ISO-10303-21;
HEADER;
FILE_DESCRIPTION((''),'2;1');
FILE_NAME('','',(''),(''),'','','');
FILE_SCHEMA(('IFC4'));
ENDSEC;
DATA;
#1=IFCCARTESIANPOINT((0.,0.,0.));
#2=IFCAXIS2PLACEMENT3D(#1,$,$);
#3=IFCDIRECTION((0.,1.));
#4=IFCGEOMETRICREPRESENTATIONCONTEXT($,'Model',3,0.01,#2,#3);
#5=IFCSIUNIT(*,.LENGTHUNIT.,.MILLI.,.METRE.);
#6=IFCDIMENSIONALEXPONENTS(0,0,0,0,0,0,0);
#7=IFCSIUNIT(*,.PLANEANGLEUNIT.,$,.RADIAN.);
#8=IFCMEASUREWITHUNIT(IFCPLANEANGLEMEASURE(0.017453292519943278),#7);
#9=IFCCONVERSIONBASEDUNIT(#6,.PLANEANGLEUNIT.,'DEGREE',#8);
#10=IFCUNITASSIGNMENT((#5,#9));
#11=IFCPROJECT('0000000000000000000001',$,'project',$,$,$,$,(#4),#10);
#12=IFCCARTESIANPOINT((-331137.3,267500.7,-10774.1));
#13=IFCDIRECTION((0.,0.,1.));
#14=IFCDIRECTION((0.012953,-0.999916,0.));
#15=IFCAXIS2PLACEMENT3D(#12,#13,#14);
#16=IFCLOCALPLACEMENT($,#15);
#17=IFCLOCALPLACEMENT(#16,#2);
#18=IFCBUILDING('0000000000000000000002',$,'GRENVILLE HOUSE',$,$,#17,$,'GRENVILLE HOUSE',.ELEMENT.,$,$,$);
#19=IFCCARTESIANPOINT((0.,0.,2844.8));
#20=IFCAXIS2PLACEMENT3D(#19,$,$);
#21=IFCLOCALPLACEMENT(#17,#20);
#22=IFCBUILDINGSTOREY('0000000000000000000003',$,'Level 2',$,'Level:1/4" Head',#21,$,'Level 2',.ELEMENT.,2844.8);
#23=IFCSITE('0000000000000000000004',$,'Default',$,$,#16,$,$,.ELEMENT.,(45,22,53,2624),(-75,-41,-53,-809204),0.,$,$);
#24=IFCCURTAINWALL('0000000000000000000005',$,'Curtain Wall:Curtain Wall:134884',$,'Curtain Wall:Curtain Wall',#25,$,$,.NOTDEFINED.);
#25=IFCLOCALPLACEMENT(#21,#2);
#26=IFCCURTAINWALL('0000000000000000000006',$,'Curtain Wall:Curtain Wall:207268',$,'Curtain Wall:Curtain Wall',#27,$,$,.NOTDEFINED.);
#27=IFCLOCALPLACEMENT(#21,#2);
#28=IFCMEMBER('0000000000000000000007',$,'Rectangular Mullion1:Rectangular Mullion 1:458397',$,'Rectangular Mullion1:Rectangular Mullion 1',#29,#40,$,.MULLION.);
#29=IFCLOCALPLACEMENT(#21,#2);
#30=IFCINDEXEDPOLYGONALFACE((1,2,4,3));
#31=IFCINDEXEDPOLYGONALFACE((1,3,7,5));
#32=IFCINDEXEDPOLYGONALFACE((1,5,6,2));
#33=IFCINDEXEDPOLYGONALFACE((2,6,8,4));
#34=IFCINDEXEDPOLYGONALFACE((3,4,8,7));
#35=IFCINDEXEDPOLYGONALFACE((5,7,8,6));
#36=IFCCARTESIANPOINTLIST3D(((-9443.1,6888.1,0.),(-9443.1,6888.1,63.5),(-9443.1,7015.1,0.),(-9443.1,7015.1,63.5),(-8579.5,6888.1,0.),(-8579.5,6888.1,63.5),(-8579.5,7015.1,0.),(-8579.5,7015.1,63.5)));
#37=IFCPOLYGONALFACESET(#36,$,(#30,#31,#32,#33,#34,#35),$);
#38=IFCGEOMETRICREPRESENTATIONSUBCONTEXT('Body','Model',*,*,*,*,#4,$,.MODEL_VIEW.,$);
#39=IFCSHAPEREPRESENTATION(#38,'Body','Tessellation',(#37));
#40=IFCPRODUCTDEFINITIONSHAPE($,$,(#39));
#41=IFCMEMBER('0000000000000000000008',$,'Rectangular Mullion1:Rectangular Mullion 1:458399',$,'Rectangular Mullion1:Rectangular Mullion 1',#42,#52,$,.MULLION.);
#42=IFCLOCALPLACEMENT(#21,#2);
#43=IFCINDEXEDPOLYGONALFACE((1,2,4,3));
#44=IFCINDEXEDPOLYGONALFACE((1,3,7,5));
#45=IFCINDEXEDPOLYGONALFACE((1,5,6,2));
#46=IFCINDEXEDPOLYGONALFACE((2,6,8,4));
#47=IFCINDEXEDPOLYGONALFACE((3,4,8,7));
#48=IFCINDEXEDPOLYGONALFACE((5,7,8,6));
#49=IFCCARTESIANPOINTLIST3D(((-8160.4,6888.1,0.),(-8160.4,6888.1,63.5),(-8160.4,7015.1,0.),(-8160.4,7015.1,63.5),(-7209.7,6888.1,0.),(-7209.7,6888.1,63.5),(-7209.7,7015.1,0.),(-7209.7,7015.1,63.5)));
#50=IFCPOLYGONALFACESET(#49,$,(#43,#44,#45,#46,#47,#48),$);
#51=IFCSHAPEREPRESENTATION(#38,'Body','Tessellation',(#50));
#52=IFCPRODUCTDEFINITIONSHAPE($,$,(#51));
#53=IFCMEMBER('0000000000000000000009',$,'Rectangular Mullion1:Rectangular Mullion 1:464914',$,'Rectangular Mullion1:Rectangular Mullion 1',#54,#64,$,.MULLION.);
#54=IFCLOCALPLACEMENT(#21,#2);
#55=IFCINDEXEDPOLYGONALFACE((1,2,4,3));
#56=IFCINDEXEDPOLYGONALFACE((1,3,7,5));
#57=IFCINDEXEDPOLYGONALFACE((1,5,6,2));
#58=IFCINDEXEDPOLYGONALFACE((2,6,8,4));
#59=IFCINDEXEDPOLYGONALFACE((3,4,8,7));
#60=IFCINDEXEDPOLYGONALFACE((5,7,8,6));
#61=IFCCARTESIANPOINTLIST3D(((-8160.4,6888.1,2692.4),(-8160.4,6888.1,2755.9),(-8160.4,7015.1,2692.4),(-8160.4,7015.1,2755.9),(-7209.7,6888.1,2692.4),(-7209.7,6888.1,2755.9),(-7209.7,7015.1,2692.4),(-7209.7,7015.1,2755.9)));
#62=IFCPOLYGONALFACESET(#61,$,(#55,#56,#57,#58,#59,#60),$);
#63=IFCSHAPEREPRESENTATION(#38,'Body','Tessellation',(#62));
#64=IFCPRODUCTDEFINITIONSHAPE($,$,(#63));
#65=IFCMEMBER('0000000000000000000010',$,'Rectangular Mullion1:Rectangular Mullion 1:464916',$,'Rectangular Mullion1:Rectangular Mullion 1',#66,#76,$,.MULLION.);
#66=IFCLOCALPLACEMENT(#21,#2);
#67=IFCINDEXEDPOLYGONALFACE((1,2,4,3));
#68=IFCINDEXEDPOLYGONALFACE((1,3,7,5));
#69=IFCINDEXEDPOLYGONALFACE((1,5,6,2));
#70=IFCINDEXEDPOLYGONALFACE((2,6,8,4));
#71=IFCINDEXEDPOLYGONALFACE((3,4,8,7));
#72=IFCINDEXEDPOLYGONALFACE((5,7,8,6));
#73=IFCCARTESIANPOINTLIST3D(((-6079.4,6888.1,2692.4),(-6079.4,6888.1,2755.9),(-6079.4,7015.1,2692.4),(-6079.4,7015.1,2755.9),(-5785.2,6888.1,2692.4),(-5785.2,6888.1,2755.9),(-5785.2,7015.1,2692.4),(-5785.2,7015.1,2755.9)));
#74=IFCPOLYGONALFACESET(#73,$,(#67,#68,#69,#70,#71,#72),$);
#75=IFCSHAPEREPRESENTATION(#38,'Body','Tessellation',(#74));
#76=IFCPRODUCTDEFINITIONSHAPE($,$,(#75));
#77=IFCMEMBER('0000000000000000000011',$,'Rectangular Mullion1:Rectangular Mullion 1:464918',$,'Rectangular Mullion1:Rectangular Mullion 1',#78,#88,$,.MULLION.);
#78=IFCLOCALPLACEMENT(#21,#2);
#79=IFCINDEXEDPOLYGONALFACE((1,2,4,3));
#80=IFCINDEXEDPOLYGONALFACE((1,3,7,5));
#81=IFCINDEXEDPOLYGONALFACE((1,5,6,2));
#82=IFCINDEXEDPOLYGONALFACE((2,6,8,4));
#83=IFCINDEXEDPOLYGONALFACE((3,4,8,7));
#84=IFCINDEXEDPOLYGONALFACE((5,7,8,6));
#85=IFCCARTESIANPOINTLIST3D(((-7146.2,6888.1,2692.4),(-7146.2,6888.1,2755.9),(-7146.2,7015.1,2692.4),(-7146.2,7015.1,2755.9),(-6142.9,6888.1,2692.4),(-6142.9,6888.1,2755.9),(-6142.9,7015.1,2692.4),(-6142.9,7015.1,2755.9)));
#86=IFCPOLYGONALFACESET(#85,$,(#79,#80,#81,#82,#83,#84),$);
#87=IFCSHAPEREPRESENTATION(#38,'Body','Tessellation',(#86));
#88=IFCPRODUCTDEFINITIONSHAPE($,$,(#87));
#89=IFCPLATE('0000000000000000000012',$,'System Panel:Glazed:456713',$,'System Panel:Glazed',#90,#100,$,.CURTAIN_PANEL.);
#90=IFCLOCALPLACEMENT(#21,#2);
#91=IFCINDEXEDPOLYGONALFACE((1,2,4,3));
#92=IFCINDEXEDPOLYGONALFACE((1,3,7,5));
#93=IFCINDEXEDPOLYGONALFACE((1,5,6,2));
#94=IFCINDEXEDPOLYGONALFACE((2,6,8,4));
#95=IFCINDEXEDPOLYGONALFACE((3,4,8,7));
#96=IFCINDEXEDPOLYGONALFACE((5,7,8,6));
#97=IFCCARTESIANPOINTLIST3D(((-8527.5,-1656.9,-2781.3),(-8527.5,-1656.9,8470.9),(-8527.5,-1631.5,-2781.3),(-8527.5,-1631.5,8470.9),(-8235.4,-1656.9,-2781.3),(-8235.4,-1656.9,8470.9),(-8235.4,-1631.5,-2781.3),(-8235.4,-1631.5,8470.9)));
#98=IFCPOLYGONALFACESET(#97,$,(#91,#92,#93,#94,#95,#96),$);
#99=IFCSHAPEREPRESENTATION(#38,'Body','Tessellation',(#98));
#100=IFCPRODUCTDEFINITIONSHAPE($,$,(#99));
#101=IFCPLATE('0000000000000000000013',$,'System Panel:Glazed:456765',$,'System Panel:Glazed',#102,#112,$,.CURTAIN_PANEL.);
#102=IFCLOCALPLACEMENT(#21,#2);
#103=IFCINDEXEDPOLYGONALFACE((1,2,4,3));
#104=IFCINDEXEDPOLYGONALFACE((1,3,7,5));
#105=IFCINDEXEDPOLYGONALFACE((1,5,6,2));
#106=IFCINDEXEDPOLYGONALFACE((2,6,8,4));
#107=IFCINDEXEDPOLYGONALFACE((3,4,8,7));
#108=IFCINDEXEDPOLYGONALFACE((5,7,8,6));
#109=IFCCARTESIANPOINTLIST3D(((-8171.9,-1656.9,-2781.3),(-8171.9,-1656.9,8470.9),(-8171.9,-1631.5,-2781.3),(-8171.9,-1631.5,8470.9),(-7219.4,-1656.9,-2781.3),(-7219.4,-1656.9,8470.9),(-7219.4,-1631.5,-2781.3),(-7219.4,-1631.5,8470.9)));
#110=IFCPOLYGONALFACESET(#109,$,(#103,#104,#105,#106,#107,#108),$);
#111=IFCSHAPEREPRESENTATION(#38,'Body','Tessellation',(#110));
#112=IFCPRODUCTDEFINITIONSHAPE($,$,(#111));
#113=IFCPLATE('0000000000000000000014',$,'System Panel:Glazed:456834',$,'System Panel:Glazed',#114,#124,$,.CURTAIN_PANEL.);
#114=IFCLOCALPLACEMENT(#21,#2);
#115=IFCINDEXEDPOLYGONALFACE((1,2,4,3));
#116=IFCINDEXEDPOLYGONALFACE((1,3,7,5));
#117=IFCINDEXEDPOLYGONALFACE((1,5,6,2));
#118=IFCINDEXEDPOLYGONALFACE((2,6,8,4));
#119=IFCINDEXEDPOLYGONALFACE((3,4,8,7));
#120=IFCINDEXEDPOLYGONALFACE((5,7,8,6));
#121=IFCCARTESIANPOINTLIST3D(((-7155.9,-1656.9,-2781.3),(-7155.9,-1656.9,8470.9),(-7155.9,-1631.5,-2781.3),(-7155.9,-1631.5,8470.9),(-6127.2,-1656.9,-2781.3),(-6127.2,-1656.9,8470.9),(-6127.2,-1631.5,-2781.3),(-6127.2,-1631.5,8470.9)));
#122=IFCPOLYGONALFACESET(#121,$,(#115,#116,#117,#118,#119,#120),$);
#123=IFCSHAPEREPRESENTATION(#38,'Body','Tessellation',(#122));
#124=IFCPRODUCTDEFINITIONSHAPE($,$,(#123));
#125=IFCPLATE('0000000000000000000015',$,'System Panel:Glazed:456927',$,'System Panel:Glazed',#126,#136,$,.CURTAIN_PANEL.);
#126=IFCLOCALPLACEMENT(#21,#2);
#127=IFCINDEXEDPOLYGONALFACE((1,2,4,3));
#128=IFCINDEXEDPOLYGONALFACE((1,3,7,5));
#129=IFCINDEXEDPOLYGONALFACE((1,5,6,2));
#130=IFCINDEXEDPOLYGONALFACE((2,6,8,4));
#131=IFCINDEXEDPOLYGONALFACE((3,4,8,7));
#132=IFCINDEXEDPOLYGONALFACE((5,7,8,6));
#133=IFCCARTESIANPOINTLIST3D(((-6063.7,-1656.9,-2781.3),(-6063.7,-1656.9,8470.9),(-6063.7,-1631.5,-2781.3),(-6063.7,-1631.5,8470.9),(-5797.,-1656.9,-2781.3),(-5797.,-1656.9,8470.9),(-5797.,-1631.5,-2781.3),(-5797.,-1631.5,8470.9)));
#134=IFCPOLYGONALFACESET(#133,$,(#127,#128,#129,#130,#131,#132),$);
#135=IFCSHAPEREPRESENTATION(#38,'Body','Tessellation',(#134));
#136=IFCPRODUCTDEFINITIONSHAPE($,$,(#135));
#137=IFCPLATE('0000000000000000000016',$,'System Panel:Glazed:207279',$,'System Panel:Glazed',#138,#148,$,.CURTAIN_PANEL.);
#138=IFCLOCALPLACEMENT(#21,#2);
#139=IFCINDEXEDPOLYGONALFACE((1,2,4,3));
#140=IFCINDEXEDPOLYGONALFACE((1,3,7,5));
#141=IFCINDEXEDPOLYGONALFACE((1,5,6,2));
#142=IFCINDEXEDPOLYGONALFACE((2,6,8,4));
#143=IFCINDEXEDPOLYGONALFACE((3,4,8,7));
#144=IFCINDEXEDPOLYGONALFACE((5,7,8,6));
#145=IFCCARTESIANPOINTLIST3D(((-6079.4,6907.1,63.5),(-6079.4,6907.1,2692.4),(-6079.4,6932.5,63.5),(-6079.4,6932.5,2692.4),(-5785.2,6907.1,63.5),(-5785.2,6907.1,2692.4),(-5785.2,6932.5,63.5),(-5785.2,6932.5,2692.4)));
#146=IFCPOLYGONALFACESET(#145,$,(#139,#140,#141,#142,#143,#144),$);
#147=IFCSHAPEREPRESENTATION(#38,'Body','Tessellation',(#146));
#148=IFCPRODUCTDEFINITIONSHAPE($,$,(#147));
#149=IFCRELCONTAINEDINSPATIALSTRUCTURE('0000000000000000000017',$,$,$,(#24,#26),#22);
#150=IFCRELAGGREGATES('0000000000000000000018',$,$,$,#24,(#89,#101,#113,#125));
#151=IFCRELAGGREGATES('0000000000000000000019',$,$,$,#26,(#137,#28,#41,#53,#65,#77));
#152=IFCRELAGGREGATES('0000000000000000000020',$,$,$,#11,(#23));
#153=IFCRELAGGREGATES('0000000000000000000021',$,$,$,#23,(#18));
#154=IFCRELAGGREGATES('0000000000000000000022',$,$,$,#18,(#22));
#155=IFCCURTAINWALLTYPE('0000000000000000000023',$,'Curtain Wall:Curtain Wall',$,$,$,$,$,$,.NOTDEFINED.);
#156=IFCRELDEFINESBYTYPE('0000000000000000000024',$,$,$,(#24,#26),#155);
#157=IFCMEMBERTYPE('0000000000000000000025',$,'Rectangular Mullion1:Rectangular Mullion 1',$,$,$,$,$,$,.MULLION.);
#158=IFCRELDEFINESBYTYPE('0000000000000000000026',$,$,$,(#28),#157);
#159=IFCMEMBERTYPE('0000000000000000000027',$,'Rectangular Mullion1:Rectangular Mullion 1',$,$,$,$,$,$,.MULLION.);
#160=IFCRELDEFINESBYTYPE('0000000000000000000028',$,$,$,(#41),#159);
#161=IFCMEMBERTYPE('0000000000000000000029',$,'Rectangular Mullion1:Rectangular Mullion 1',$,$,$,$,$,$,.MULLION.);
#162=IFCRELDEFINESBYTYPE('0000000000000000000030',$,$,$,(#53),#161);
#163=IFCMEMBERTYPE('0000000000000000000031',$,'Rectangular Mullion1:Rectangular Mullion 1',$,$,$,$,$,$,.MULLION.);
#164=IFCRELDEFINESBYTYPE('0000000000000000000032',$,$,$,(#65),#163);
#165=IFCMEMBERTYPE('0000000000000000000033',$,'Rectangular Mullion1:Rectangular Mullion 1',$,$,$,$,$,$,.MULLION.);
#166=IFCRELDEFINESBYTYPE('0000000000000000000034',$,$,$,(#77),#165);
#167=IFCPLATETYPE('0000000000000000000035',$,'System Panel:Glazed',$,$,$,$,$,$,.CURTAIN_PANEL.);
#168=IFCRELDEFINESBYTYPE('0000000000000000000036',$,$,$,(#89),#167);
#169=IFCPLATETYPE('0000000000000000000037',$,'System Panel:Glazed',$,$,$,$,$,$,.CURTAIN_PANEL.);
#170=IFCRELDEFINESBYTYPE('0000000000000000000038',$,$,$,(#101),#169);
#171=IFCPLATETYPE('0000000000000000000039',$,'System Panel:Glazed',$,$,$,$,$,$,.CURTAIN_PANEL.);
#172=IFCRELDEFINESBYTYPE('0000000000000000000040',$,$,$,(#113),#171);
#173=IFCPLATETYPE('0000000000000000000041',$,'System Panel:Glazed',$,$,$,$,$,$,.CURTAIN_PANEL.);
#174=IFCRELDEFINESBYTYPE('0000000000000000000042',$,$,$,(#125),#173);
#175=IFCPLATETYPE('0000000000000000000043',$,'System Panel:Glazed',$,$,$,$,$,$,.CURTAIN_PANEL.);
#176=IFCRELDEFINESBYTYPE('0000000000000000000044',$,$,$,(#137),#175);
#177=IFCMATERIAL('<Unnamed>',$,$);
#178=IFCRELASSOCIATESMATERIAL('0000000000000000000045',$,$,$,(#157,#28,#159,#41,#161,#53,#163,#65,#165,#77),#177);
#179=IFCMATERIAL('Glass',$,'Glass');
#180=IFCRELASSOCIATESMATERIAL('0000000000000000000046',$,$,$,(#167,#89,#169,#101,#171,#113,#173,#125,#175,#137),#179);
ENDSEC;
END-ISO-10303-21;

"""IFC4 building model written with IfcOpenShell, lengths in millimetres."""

from ifc_helpers import new_model, entity, si_unit, converted_unit, direction, frame, origin, place, context, subcontext, project, spatial, indexed_curve, outline, extrude, source, transform, mapped, material, type_object, type_shapes, element, aggregate, save


model = new_model("IFC4")

# Units and contexts
model_context = context("Model", 3, precision=0.01, world=origin(), true_north=direction((0.0, 1.0)))
body_context = subcontext(model_context, "Body", "Model", "MODEL_VIEW")
ifc_project = project(units=[si_unit("LENGTHUNIT", "METRE", prefix="MILLI"), converted_unit("PLANEANGLEUNIT", "DEGREE", entity("IfcPlaneAngleMeasure", 0.017453292519943278), si_unit("PLANEANGLEUNIT", "RADIAN"), dimensions=[0, 0, 0, 0, 0, 0, 0])], contexts=[model_context])

# Site, building, storey
site_placement = place(None, frame((-331137.3, 267500.7, -10774.1), z_axis=(0.0, 0.0, 1.0), x_axis=(0.012953, -0.999916, 0.0)))
site = spatial("IfcSite", under=ifc_project, at=site_placement, Name="Default", CompositionType="ELEMENT", RefLatitude=(45, 22, 53, 2624), RefLongitude=(-75, -41, -53, -809204), RefElevation=0.0)
building_placement = place(site_placement, origin())
building = spatial("IfcBuilding", under=site, at=building_placement, Name="GRENVILLE HOUSE", LongName="GRENVILLE HOUSE", CompositionType="ELEMENT")
storey_placement = place(building_placement, frame((0.0, 0.0, 2844.8)))
storey = spatial("IfcBuildingStorey", under=building, at=storey_placement, Name="Level 2", ObjectType="Level:1/4\" Head", LongName="Level 2", CompositionType="ELEMENT", Elevation=2844.8)

# Curtain wall
curtain_wall_type = type_object("IfcCurtainWallType", Name="Curtain Wall:Curtain Wall", PredefinedType="NOTDEFINED")
curtain_wall_1_placement = place(storey_placement, frame((0.0, 0.0, -2844.8)))
curtain_wall_1 = element("IfcCurtainWall", 1, at=curtain_wall_1_placement, inside=storey, type_object=curtain_wall_type, Name="Curtain Wall:Curtain Wall:134884", ObjectType="Curtain Wall:Curtain Wall", PredefinedType="NOTDEFINED")
ifc_material_1 = material(Name="<Unnamed>")

# Curtain wall
curtain_wall_2_placement = place(storey_placement, frame((0.0, 0.0, -2844.8)))
curtain_wall_2 = element("IfcCurtainWall", 2, at=curtain_wall_2_placement, inside=storey, type_object=curtain_wall_type, Name="Curtain Wall:Curtain Wall:207268", ObjectType="Curtain Wall:Curtain Wall", PredefinedType="NOTDEFINED")

# Members
member_type_1 = type_object("IfcMemberType", Name="Rectangular Mullion1:Rectangular Mullion 1", PredefinedType="MULLION", material=ifc_material_1)
shared_shape_1 = source(origin(), body_context, "Body", "SweptSolid", [
    extrude(outline(indexed_curve([(-31.8, -63.5), (31.8, -63.5), (31.8, 63.5), (-31.8, 63.5), (-31.8, -63.5)], self_intersect=False)), frame((-31.8, 0.0, -863.6), z_axis=(0.0, 0.0, 1.0), x_axis=(-1.0, 0.0, 0.0)), (0.0, 0.0, 1.0), 863.6),
])
type_shapes(member_type_1, [shared_shape_1])
member_1_placement = place(curtain_wall_2_placement, frame((-8579.5, 6951.6, 2844.8), z_axis=(1.0, 0.0, 0.0), x_axis=(0.0, 0.0, -1.0)))
member_1 = element("IfcMember", 3, at=member_1_placement, type_object=member_type_1, material=ifc_material_1, Name="Rectangular Mullion1:Rectangular Mullion 1:458397", ObjectType="Rectangular Mullion1:Rectangular Mullion 1", PredefinedType="MULLION", context=body_context, shape_type="MappedRepresentation", body=[
    mapped(shared_shape_1, transform((0.0, 0.0, 0.0), scale=1.0)),
])
member_type_2 = type_object("IfcMemberType", Name="Rectangular Mullion1:Rectangular Mullion 1", PredefinedType="MULLION", material=ifc_material_1)
shared_shape_2 = source(origin(), body_context, "Body", "SweptSolid", [
    extrude(outline(indexed_curve([(-31.8, -63.5), (31.8, -63.5), (31.8, 63.5), (-31.8, 63.5), (-31.8, -63.5)], self_intersect=False)), frame((-31.8, 0.0, -950.7), z_axis=(0.0, 0.0, 1.0), x_axis=(-1.0, 0.0, 0.0)), (0.0, 0.0, 1.0), 950.7),
])
type_shapes(member_type_2, [shared_shape_2])
member_2_placement = place(curtain_wall_2_placement, frame((-7209.7, 6951.6, 2844.8), z_axis=(1.0, 0.0, 0.0), x_axis=(0.0, 0.0, -1.0)))
member_2 = element("IfcMember", 4, at=member_2_placement, type_object=member_type_2, material=ifc_material_1, Name="Rectangular Mullion1:Rectangular Mullion 1:458399", ObjectType="Rectangular Mullion1:Rectangular Mullion 1", PredefinedType="MULLION", context=body_context, shape_type="MappedRepresentation", body=[
    mapped(shared_shape_2, transform((0.0, 0.0, 0.0), scale=1.0)),
])
member_type_3 = type_object("IfcMemberType", Name="Rectangular Mullion1:Rectangular Mullion 1", PredefinedType="MULLION", material=ifc_material_1)
shared_shape_3 = source(origin(), body_context, "Body", "SweptSolid", [
    extrude(outline(indexed_curve([(-31.8, -63.5), (31.8, -63.5), (31.8, 63.5), (-31.8, 63.5), (-31.8, -63.5)], self_intersect=False)), frame((-31.8, 0.0, -950.7), z_axis=(0.0, 0.0, 1.0), x_axis=(-1.0, 0.0, 0.0)), (0.0, 0.0, 1.0), 950.7),
])
type_shapes(member_type_3, [shared_shape_3])
member_3_placement = place(curtain_wall_2_placement, frame((-8160.4, 6951.6, 5600.7), z_axis=(-1.0, 0.0, 0.0), x_axis=(0.0, 0.0, 1.0)))
member_3 = element("IfcMember", 5, at=member_3_placement, type_object=member_type_3, material=ifc_material_1, Name="Rectangular Mullion1:Rectangular Mullion 1:464914", ObjectType="Rectangular Mullion1:Rectangular Mullion 1", PredefinedType="MULLION", context=body_context, shape_type="MappedRepresentation", body=[
    mapped(shared_shape_3, transform((0.0, 0.0, 0.0), scale=1.0)),
])
member_type_4 = type_object("IfcMemberType", Name="Rectangular Mullion1:Rectangular Mullion 1", PredefinedType="MULLION", material=ifc_material_1)
shared_shape_4 = source(origin(), body_context, "Body", "SweptSolid", [
    extrude(outline(indexed_curve([(-31.8, -63.5), (31.8, -63.5), (31.8, 63.5), (-31.8, 63.5), (-31.8, -63.5)], self_intersect=False)), frame((-31.8, 0.0, -294.2), z_axis=(0.0, 0.0, 1.0), x_axis=(-1.0, 0.0, 0.0)), (0.0, 0.0, 1.0), 294.2),
])
type_shapes(member_type_4, [shared_shape_4])
member_4_placement = place(curtain_wall_2_placement, frame((-6079.4, 6951.6, 5600.7), z_axis=(-1.0, 0.0, 0.0), x_axis=(0.0, 0.0, 1.0)))
member_4 = element("IfcMember", 6, at=member_4_placement, type_object=member_type_4, material=ifc_material_1, Name="Rectangular Mullion1:Rectangular Mullion 1:464916", ObjectType="Rectangular Mullion1:Rectangular Mullion 1", PredefinedType="MULLION", context=body_context, shape_type="MappedRepresentation", body=[
    mapped(shared_shape_4, transform((0.0, 0.0, 0.0), scale=1.0)),
])
member_type_5 = type_object("IfcMemberType", Name="Rectangular Mullion1:Rectangular Mullion 1", PredefinedType="MULLION", material=ifc_material_1)
shared_shape_5 = source(origin(), body_context, "Body", "SweptSolid", [
    extrude(outline(indexed_curve([(-31.8, -63.5), (31.8, -63.5), (31.8, 63.5), (-31.8, 63.5), (-31.8, -63.5)], self_intersect=False)), frame((-31.8, 0.0, -1003.3), z_axis=(0.0, 0.0, 1.0), x_axis=(-1.0, 0.0, 0.0)), (0.0, 0.0, 1.0), 1003.3),
])
type_shapes(member_type_5, [shared_shape_5])
member_5_placement = place(curtain_wall_2_placement, frame((-7146.2, 6951.6, 5600.7), z_axis=(-1.0, 0.0, 0.0), x_axis=(0.0, 0.0, 1.0)))
member_5 = element("IfcMember", 7, at=member_5_placement, type_object=member_type_5, material=ifc_material_1, Name="Rectangular Mullion1:Rectangular Mullion 1:464918", ObjectType="Rectangular Mullion1:Rectangular Mullion 1", PredefinedType="MULLION", context=body_context, shape_type="MappedRepresentation", body=[
    mapped(shared_shape_5, transform((0.0, 0.0, 0.0), scale=1.0)),
])

# Plates
ifc_material_2 = material(Name="Glass", Category="Glass")
plate_type_1 = type_object("IfcPlateType", Name="System Panel:Glazed", PredefinedType="CURTAIN_PANEL", material=ifc_material_2)
shared_shape_6 = source(origin(), body_context, "Body", "SweptSolid", [
    extrude(outline(indexed_curve([(-12.7, -146.0), (12.7, -146.0), (12.7, 146.0), (-12.7, 146.0), (-12.7, -146.0)], self_intersect=False)), frame((146.0, 12.7, 0.0), z_axis=(0.0, 0.0, 1.0), x_axis=(0.0, 1.0, 0.0)), (0.0, 0.0, 1.0), 11252.2),
])
type_shapes(plate_type_1, [shared_shape_6])
plate_1_placement = place(curtain_wall_1_placement, frame((-8527.5, -1656.9, 63.5)))
plate_1 = element("IfcPlate", 8, at=plate_1_placement, type_object=plate_type_1, material=ifc_material_2, Name="System Panel:Glazed:456713", ObjectType="System Panel:Glazed", PredefinedType="CURTAIN_PANEL", context=body_context, shape_type="MappedRepresentation", body=[
    mapped(shared_shape_6, transform((0.0, 0.0, 0.0), scale=1.0)),
])
plate_type_2 = type_object("IfcPlateType", Name="System Panel:Glazed", PredefinedType="CURTAIN_PANEL", material=ifc_material_2)
shared_shape_7 = source(origin(), body_context, "Body", "SweptSolid", [
    extrude(outline(indexed_curve([(-12.7, -476.2), (12.7, -476.2), (12.7, 476.2), (-12.7, 476.2), (-12.7, -476.2)], self_intersect=False)), frame((476.2, 12.7, 0.0), z_axis=(0.0, 0.0, 1.0), x_axis=(0.0, 1.0, 0.0)), (0.0, 0.0, 1.0), 11252.2),
])
type_shapes(plate_type_2, [shared_shape_7])
plate_2_placement = place(curtain_wall_1_placement, frame((-8171.9, -1656.9, 63.5)))
plate_2 = element("IfcPlate", 9, at=plate_2_placement, type_object=plate_type_2, material=ifc_material_2, Name="System Panel:Glazed:456765", ObjectType="System Panel:Glazed", PredefinedType="CURTAIN_PANEL", context=body_context, shape_type="MappedRepresentation", body=[
    mapped(shared_shape_7, transform((0.0, 0.0, 0.0), scale=1.0)),
])
plate_type_3 = type_object("IfcPlateType", Name="System Panel:Glazed", PredefinedType="CURTAIN_PANEL", material=ifc_material_2)
shared_shape_8 = source(origin(), body_context, "Body", "SweptSolid", [
    extrude(outline(indexed_curve([(-12.7, -514.3), (12.7, -514.3), (12.7, 514.3), (-12.7, 514.3), (-12.7, -514.3)], self_intersect=False)), frame((514.3, 12.7, 0.0), z_axis=(0.0, 0.0, 1.0), x_axis=(0.0, 1.0, 0.0)), (0.0, 0.0, 1.0), 11252.2),
])
type_shapes(plate_type_3, [shared_shape_8])
plate_3_placement = place(curtain_wall_1_placement, frame((-7155.9, -1656.9, 63.5)))
plate_3 = element("IfcPlate", 10, at=plate_3_placement, type_object=plate_type_3, material=ifc_material_2, Name="System Panel:Glazed:456834", ObjectType="System Panel:Glazed", PredefinedType="CURTAIN_PANEL", context=body_context, shape_type="MappedRepresentation", body=[
    mapped(shared_shape_8, transform((0.0, 0.0, 0.0), scale=1.0)),
])
plate_type_4 = type_object("IfcPlateType", Name="System Panel:Glazed", PredefinedType="CURTAIN_PANEL", material=ifc_material_2)
shared_shape_9 = source(origin(), body_context, "Body", "SweptSolid", [
    extrude(outline(indexed_curve([(-12.7, -133.3), (12.7, -133.3), (12.7, 133.3), (-12.7, 133.3), (-12.7, -133.3)], self_intersect=False)), frame((133.3, 12.7, 0.0), z_axis=(0.0, 0.0, 1.0), x_axis=(0.0, 1.0, 0.0)), (0.0, 0.0, 1.0), 11252.2),
])
type_shapes(plate_type_4, [shared_shape_9])
plate_4_placement = place(curtain_wall_1_placement, frame((-6063.7, -1656.9, 63.5)))
plate_4 = element("IfcPlate", 11, at=plate_4_placement, type_object=plate_type_4, material=ifc_material_2, Name="System Panel:Glazed:456927", ObjectType="System Panel:Glazed", PredefinedType="CURTAIN_PANEL", context=body_context, shape_type="MappedRepresentation", body=[
    mapped(shared_shape_9, transform((0.0, 0.0, 0.0), scale=1.0)),
])
aggregate(curtain_wall_1, [plate_1, plate_2, plate_3, plate_4])
plate_type_5 = type_object("IfcPlateType", Name="System Panel:Glazed", PredefinedType="CURTAIN_PANEL", material=ifc_material_2)
shared_shape_10 = source(origin(), body_context, "Body", "SweptSolid", [
    extrude(outline(indexed_curve([(-12.7, -147.1), (12.7, -147.1), (12.7, 147.1), (-12.7, 147.1), (-12.7, -147.1)], self_intersect=False)), frame((147.1, 12.7, 0.0), z_axis=(0.0, 0.0, 1.0), x_axis=(0.0, 1.0, 0.0)), (0.0, 0.0, 1.0), 2628.9),
])
type_shapes(plate_type_5, [shared_shape_10])
plate_5_placement = place(curtain_wall_2_placement, frame((-5785.2, 6932.5, 2908.3), z_axis=(0.0, 0.0, 1.0), x_axis=(-1.0, 0.0, 0.0)))
plate_5 = element("IfcPlate", 12, at=plate_5_placement, type_object=plate_type_5, material=ifc_material_2, Name="System Panel:Glazed:207279", ObjectType="System Panel:Glazed", PredefinedType="CURTAIN_PANEL", context=body_context, shape_type="MappedRepresentation", body=[
    mapped(shared_shape_10, transform((0.0, 0.0, 0.0), scale=1.0)),
])
aggregate(curtain_wall_2, [plate_5, member_1, member_2, member_3, member_4, member_5])

save(model, "model.ifc")
